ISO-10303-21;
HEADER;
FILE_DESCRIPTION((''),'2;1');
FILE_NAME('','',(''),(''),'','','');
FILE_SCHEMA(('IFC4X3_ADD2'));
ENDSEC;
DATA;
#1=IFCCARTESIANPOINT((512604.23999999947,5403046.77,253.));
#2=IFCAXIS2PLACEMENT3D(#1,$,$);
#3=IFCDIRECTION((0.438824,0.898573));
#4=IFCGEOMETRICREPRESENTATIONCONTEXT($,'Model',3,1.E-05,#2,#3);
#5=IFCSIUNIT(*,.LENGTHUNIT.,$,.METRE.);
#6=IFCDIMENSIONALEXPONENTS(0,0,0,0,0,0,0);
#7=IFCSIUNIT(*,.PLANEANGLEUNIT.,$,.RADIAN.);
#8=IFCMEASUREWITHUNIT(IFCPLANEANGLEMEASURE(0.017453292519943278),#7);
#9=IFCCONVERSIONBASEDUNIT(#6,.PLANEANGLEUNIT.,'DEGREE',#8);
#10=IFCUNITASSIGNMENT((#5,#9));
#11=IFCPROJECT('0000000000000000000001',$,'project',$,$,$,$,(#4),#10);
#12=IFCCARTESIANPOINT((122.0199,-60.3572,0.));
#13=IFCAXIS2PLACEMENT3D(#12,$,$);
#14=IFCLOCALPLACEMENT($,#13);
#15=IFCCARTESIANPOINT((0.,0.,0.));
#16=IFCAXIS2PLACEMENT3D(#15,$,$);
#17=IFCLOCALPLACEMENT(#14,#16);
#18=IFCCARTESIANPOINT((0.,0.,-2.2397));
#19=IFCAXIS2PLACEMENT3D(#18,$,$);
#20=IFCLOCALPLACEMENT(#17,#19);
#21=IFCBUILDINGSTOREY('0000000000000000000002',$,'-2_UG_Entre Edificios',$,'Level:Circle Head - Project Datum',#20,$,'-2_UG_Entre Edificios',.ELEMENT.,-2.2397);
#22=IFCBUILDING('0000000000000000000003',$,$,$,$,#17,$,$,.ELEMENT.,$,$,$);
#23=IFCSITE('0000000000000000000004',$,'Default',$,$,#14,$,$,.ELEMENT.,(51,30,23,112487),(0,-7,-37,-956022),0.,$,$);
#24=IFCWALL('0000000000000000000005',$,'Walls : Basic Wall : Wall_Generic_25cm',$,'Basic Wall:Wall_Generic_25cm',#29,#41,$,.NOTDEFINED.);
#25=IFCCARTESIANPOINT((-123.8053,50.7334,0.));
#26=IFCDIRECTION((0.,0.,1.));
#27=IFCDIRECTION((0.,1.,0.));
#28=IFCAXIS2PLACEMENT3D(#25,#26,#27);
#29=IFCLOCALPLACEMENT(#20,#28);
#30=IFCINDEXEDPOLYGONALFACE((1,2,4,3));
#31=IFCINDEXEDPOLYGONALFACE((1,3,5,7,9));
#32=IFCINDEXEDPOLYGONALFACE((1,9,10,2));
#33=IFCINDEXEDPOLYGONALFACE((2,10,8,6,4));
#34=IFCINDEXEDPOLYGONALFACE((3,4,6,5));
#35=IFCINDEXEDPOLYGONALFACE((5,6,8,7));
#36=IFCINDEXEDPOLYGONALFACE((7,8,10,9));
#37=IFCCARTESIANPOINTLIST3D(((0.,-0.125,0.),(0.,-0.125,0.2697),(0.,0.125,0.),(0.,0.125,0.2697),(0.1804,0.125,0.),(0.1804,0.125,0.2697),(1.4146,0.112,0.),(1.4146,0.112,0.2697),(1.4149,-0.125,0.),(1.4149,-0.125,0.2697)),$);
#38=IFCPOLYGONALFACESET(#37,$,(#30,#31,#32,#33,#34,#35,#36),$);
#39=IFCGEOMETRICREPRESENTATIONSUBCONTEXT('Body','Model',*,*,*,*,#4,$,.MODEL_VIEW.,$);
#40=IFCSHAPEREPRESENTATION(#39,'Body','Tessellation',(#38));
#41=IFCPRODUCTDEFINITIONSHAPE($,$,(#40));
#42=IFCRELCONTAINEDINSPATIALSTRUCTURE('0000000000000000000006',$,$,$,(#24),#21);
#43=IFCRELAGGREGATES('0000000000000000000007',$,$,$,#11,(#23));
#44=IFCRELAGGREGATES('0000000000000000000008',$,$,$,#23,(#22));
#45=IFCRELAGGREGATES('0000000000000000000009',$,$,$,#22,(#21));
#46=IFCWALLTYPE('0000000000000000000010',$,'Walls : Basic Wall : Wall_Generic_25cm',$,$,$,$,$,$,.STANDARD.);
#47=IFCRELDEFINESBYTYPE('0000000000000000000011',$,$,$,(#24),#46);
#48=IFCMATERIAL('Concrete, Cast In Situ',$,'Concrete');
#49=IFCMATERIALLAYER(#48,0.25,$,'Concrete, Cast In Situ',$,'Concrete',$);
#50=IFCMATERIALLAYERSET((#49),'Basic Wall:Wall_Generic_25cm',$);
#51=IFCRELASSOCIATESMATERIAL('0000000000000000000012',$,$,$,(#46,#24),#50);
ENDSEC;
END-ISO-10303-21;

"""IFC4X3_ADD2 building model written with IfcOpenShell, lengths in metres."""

from ifc_helpers import new_model, entity, si_unit, converted_unit, direction, frame, origin, place, context, subcontext, project, spatial, polyline, outline, extrude, clip, halfspace, bounded_halfspace, material, layer, layer_set, type_object, element, save


model = new_model("IFC4X3_ADD2")

# Units and contexts
model_context = context("Model", 3, precision=1e-05, world=frame((512604.23999999947, 5403046.77, 253.0)), true_north=direction((0.438824, 0.898573)))
body_context = subcontext(model_context, "Body", "Model", "MODEL_VIEW")
ifc_project = project(units=[si_unit("LENGTHUNIT", "METRE"), converted_unit("PLANEANGLEUNIT", "DEGREE", entity("IfcPlaneAngleMeasure", 0.017453292519943278), si_unit("PLANEANGLEUNIT", "RADIAN"), dimensions=[0, 0, 0, 0, 0, 0, 0])], contexts=[model_context])

# Site, building, storey
site_placement = place(None, frame((122.0199, -60.3572, 0.0)))
site = spatial("IfcSite", under=ifc_project, at=site_placement, Name="Default", CompositionType="ELEMENT", RefLatitude=(51, 30, 23, 112487), RefLongitude=(0, -7, -37, -956022), RefElevation=0.0)
building_placement = place(site_placement, origin())
building = spatial("IfcBuilding", under=site, at=building_placement, CompositionType="ELEMENT")
storey_placement = place(building_placement, frame((0.0, 0.0, -2.2397)))
storey = spatial("IfcBuildingStorey", under=building, at=storey_placement, Name="-2_UG_Entre Edificios", ObjectType="Level:Circle Head - Project Datum", LongName="-2_UG_Entre Edificios", CompositionType="ELEMENT", Elevation=-2.2397)

# Shared definitions
ifc_material_1 = material(Name="Concrete, Cast In Situ", Category="Concrete")

# Wall
ifc_layer_1 = layer(ifc_material_1, 0.25, Name="Concrete, Cast In Situ", Category="Concrete")
ifc_layer_set_1 = layer_set([ifc_layer_1], Name="Basic Wall:Wall_Generic_25cm")
wall_type_1 = type_object("IfcWallType", Name="Walls : Basic Wall : Wall_Generic_25cm", PredefinedType="STANDARD", material=ifc_layer_set_1)
wall_1_placement = place(storey_placement, frame((-123.8053, 50.7334, 0.0), z_axis=(0.0, 0.0, 1.0), x_axis=(0.0, 1.0, 0.0)))
element("IfcWall", 1, at=wall_1_placement, inside=storey, type_object=wall_type_1, material=ifc_layer_set_1, Name="Walls : Basic Wall : Wall_Generic_25cm", ObjectType="Basic Wall:Wall_Generic_25cm", PredefinedType="NOTDEFINED", context=body_context, shape_type="Clipping", body=[
    clip(clip(extrude(outline(polyline([(1.4149, -0.125), (1.4146, 0.112), (1.2946, 0.1133), (0.1804, 0.125), (0.0, 0.125), (0.0, -0.125), (1.4149, -0.125)])), origin(), (0.0, 0.0, 1.0), 0.2697), bounded_halfspace(frame((0.1804, 0.125, -1.0603), z_axis=(-0.010506, -0.999945, 0.0), x_axis=(0.999945, -0.010506, 0.0)), True, frame((0.1804, 0.125, -1.0603), z_axis=(-0.010506, -0.999945, 0.0), x_axis=(0.999945, -0.010506, 0.0)), polyline([(0.0, 0.0), (1.1142, 0.0), (1.2342, 0.0), (1.2342, 1.33), (0.0, 1.33), (0.0, 0.0)]))), halfspace(frame((0.0, 0.0, -1.0603)), True)),
])

save(model, "model.ifc")
